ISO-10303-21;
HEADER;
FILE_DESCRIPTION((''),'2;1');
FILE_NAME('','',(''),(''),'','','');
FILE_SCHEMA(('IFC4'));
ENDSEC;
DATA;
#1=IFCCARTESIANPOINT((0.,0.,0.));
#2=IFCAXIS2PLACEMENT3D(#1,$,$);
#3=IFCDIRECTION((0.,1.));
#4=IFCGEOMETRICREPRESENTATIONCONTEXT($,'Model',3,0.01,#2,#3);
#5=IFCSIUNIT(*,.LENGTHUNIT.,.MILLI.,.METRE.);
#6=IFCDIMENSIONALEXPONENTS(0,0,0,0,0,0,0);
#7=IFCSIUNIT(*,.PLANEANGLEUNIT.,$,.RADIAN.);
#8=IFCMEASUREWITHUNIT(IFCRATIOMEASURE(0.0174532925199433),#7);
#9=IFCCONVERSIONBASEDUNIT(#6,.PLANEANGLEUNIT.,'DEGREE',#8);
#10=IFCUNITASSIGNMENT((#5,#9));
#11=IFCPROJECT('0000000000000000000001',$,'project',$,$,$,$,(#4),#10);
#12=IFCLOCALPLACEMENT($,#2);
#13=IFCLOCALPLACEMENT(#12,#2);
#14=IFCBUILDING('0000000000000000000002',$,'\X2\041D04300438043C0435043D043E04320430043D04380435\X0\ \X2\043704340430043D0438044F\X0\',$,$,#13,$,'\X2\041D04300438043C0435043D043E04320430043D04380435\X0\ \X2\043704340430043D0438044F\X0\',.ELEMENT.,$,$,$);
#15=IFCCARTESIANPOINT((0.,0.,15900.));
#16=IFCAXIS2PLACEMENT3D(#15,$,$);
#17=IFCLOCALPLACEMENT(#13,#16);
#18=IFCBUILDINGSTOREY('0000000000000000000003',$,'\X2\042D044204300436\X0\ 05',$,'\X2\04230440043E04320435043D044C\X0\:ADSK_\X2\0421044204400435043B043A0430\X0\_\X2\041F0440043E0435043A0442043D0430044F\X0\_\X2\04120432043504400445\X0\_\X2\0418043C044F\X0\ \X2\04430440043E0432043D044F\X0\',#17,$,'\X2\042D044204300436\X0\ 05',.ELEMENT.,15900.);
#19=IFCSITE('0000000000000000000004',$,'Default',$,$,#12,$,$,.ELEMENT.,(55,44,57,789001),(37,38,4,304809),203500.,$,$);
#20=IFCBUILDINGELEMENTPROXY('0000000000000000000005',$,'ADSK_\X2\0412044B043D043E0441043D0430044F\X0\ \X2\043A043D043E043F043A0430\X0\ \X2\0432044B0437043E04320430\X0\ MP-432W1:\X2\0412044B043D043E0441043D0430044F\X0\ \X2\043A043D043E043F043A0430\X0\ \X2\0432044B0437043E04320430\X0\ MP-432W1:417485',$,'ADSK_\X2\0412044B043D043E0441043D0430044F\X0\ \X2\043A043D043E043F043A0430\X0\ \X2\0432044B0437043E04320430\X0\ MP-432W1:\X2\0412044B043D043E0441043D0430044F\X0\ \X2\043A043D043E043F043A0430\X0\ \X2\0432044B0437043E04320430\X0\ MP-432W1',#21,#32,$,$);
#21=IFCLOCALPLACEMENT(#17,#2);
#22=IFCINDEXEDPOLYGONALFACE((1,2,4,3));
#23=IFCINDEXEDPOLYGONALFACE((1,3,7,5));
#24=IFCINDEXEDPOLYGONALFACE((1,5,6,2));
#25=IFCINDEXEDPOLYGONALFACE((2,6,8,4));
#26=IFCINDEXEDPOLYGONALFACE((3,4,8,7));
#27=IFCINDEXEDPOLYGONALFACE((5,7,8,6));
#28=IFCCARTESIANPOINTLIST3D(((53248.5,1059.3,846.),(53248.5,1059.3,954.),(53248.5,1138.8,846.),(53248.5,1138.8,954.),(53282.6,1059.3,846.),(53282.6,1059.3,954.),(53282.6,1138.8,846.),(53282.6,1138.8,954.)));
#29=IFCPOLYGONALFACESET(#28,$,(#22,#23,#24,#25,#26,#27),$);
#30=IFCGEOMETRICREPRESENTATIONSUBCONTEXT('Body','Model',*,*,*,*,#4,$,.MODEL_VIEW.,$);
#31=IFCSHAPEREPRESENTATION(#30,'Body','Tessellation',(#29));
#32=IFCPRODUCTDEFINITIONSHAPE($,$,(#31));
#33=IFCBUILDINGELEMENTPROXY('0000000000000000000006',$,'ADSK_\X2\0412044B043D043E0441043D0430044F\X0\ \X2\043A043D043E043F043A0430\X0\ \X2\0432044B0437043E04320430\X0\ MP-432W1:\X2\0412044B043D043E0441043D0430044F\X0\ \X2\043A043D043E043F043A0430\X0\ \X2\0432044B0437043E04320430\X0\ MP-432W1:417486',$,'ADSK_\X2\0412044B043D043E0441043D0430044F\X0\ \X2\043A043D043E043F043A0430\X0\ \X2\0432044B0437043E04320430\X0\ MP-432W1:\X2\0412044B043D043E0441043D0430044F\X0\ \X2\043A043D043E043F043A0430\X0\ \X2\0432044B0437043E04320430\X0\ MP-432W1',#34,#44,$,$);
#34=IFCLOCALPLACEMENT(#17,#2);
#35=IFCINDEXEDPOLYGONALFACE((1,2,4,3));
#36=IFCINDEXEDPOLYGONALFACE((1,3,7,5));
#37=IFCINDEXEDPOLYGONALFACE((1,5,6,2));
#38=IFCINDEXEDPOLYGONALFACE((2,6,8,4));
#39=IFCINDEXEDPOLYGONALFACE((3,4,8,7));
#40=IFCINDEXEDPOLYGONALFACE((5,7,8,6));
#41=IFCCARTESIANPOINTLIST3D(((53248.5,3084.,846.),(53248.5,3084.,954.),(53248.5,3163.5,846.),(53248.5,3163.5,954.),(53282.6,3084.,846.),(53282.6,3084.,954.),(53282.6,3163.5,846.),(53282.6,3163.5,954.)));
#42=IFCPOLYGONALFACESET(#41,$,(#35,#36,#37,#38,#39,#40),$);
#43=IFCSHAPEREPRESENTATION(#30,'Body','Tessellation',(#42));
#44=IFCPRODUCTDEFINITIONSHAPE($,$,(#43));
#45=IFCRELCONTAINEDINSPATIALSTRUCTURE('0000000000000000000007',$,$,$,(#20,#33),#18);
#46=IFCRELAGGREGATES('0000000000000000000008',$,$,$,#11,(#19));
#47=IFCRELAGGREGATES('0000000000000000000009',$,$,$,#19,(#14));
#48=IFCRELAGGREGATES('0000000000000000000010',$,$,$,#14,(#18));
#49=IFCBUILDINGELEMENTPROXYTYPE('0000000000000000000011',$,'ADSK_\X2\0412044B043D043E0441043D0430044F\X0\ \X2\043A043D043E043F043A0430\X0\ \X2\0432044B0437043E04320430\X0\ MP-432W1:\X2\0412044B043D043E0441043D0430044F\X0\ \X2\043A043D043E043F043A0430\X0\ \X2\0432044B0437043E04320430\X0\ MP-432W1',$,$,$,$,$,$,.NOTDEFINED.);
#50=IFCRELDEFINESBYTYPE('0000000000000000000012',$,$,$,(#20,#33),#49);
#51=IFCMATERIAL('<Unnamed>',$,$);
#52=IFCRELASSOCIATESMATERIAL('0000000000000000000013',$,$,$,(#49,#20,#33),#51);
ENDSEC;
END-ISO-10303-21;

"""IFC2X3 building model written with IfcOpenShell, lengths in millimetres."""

from ifc_helpers import new_model, entity, si_unit, converted_unit, direction, frame, origin, origin_2d_with_axis, place, context, subcontext, project, spatial, rectangle, extrude, source, transform, mapped, material, type_object, type_shapes, element, save


model = new_model("IFC2X3")

# Units and contexts
model_context = context("Model", 3, precision=0.01, world=origin(), true_north=direction((0.0, 1.0)))
body_context = subcontext(model_context, "Body", "Model", "MODEL_VIEW")
ifc_project = project(units=[si_unit("LENGTHUNIT", "METRE", prefix="MILLI"), converted_unit("PLANEANGLEUNIT", "DEGREE", entity("IfcRatioMeasure", 0.0174532925199433), si_unit("PLANEANGLEUNIT", "RADIAN"), dimensions=[0, 0, 0, 0, 0, 0, 0])], contexts=[model_context])

# Site, building, storey
site_placement = place(None, origin())
site = spatial("IfcSite", under=ifc_project, at=site_placement, Name="Default", CompositionType="ELEMENT", RefLatitude=(55, 44, 57, 789001), RefLongitude=(37, 38, 4, 304809), RefElevation=203500.0)
building_placement = place(site_placement, origin())
building = spatial("IfcBuilding", under=site, at=building_placement, Name="Наименование здания", LongName="Наименование здания", CompositionType="ELEMENT")
storey_placement = place(building_placement, frame((0.0, 0.0, 15900.0)))
storey = spatial("IfcBuildingStorey", under=building, at=storey_placement, Name="Этаж 05", ObjectType="Уровень:ADSK_Стрелка_Проектная_Вверх_Имя уровня", LongName="Этаж 05", CompositionType="ELEMENT", Elevation=15900.0)

# Building element proxies
ifc_material = material(Name="<Unnamed>")
building_element_proxy_type_1 = type_object("IfcBuildingElementProxyType", Name="ADSK_Выносная кнопка вызова MP-432W1:Выносная кнопка вызова MP-432W1", PredefinedType="NOTDEFINED", material=ifc_material)
shared_shape_1 = source(origin(), body_context, "Body", "SweptSolid", [
    extrude(rectangle(XDim=79.5, YDim=34.1, at=origin_2d_with_axis()), frame((0.0, 15.0, -54.0), z_axis=(0.0, 0.0, 1.0), x_axis=(-1.0, 0.0, 0.0)), (0.0, 0.0, 1.0), 108.0),
])
type_shapes(building_element_proxy_type_1, [shared_shape_1])
for number, where, z_axis, x_axis, name in (
    (1, (53250.6, 1099.0, 900.0), (0.0, 0.0, 1.0), (0.0, -1.0, 0.0), "ADSK_Выносная кнопка вызова MP-432W1:Выносная кнопка вызова MP-432W1:417485"),
    (2, (53250.6, 3123.7, 900.0), (0.0, 0.0, 1.0), (0.0, -1.0, 0.0), "ADSK_Выносная кнопка вызова MP-432W1:Выносная кнопка вызова MP-432W1:417486"),
):
    element("IfcBuildingElementProxy", number, at=place(storey_placement, frame(where, z_axis=z_axis, x_axis=x_axis)), inside=storey, type_object=building_element_proxy_type_1, material=ifc_material, Name=name, ObjectType="ADSK_Выносная кнопка вызова MP-432W1:Выносная кнопка вызова MP-432W1", context=body_context, shape_type="MappedRepresentation", body=[
        mapped(shared_shape_1, transform((0.0, 0.0, 0.0), scale=1.0)),
    ])

save(model, "model.ifc")
